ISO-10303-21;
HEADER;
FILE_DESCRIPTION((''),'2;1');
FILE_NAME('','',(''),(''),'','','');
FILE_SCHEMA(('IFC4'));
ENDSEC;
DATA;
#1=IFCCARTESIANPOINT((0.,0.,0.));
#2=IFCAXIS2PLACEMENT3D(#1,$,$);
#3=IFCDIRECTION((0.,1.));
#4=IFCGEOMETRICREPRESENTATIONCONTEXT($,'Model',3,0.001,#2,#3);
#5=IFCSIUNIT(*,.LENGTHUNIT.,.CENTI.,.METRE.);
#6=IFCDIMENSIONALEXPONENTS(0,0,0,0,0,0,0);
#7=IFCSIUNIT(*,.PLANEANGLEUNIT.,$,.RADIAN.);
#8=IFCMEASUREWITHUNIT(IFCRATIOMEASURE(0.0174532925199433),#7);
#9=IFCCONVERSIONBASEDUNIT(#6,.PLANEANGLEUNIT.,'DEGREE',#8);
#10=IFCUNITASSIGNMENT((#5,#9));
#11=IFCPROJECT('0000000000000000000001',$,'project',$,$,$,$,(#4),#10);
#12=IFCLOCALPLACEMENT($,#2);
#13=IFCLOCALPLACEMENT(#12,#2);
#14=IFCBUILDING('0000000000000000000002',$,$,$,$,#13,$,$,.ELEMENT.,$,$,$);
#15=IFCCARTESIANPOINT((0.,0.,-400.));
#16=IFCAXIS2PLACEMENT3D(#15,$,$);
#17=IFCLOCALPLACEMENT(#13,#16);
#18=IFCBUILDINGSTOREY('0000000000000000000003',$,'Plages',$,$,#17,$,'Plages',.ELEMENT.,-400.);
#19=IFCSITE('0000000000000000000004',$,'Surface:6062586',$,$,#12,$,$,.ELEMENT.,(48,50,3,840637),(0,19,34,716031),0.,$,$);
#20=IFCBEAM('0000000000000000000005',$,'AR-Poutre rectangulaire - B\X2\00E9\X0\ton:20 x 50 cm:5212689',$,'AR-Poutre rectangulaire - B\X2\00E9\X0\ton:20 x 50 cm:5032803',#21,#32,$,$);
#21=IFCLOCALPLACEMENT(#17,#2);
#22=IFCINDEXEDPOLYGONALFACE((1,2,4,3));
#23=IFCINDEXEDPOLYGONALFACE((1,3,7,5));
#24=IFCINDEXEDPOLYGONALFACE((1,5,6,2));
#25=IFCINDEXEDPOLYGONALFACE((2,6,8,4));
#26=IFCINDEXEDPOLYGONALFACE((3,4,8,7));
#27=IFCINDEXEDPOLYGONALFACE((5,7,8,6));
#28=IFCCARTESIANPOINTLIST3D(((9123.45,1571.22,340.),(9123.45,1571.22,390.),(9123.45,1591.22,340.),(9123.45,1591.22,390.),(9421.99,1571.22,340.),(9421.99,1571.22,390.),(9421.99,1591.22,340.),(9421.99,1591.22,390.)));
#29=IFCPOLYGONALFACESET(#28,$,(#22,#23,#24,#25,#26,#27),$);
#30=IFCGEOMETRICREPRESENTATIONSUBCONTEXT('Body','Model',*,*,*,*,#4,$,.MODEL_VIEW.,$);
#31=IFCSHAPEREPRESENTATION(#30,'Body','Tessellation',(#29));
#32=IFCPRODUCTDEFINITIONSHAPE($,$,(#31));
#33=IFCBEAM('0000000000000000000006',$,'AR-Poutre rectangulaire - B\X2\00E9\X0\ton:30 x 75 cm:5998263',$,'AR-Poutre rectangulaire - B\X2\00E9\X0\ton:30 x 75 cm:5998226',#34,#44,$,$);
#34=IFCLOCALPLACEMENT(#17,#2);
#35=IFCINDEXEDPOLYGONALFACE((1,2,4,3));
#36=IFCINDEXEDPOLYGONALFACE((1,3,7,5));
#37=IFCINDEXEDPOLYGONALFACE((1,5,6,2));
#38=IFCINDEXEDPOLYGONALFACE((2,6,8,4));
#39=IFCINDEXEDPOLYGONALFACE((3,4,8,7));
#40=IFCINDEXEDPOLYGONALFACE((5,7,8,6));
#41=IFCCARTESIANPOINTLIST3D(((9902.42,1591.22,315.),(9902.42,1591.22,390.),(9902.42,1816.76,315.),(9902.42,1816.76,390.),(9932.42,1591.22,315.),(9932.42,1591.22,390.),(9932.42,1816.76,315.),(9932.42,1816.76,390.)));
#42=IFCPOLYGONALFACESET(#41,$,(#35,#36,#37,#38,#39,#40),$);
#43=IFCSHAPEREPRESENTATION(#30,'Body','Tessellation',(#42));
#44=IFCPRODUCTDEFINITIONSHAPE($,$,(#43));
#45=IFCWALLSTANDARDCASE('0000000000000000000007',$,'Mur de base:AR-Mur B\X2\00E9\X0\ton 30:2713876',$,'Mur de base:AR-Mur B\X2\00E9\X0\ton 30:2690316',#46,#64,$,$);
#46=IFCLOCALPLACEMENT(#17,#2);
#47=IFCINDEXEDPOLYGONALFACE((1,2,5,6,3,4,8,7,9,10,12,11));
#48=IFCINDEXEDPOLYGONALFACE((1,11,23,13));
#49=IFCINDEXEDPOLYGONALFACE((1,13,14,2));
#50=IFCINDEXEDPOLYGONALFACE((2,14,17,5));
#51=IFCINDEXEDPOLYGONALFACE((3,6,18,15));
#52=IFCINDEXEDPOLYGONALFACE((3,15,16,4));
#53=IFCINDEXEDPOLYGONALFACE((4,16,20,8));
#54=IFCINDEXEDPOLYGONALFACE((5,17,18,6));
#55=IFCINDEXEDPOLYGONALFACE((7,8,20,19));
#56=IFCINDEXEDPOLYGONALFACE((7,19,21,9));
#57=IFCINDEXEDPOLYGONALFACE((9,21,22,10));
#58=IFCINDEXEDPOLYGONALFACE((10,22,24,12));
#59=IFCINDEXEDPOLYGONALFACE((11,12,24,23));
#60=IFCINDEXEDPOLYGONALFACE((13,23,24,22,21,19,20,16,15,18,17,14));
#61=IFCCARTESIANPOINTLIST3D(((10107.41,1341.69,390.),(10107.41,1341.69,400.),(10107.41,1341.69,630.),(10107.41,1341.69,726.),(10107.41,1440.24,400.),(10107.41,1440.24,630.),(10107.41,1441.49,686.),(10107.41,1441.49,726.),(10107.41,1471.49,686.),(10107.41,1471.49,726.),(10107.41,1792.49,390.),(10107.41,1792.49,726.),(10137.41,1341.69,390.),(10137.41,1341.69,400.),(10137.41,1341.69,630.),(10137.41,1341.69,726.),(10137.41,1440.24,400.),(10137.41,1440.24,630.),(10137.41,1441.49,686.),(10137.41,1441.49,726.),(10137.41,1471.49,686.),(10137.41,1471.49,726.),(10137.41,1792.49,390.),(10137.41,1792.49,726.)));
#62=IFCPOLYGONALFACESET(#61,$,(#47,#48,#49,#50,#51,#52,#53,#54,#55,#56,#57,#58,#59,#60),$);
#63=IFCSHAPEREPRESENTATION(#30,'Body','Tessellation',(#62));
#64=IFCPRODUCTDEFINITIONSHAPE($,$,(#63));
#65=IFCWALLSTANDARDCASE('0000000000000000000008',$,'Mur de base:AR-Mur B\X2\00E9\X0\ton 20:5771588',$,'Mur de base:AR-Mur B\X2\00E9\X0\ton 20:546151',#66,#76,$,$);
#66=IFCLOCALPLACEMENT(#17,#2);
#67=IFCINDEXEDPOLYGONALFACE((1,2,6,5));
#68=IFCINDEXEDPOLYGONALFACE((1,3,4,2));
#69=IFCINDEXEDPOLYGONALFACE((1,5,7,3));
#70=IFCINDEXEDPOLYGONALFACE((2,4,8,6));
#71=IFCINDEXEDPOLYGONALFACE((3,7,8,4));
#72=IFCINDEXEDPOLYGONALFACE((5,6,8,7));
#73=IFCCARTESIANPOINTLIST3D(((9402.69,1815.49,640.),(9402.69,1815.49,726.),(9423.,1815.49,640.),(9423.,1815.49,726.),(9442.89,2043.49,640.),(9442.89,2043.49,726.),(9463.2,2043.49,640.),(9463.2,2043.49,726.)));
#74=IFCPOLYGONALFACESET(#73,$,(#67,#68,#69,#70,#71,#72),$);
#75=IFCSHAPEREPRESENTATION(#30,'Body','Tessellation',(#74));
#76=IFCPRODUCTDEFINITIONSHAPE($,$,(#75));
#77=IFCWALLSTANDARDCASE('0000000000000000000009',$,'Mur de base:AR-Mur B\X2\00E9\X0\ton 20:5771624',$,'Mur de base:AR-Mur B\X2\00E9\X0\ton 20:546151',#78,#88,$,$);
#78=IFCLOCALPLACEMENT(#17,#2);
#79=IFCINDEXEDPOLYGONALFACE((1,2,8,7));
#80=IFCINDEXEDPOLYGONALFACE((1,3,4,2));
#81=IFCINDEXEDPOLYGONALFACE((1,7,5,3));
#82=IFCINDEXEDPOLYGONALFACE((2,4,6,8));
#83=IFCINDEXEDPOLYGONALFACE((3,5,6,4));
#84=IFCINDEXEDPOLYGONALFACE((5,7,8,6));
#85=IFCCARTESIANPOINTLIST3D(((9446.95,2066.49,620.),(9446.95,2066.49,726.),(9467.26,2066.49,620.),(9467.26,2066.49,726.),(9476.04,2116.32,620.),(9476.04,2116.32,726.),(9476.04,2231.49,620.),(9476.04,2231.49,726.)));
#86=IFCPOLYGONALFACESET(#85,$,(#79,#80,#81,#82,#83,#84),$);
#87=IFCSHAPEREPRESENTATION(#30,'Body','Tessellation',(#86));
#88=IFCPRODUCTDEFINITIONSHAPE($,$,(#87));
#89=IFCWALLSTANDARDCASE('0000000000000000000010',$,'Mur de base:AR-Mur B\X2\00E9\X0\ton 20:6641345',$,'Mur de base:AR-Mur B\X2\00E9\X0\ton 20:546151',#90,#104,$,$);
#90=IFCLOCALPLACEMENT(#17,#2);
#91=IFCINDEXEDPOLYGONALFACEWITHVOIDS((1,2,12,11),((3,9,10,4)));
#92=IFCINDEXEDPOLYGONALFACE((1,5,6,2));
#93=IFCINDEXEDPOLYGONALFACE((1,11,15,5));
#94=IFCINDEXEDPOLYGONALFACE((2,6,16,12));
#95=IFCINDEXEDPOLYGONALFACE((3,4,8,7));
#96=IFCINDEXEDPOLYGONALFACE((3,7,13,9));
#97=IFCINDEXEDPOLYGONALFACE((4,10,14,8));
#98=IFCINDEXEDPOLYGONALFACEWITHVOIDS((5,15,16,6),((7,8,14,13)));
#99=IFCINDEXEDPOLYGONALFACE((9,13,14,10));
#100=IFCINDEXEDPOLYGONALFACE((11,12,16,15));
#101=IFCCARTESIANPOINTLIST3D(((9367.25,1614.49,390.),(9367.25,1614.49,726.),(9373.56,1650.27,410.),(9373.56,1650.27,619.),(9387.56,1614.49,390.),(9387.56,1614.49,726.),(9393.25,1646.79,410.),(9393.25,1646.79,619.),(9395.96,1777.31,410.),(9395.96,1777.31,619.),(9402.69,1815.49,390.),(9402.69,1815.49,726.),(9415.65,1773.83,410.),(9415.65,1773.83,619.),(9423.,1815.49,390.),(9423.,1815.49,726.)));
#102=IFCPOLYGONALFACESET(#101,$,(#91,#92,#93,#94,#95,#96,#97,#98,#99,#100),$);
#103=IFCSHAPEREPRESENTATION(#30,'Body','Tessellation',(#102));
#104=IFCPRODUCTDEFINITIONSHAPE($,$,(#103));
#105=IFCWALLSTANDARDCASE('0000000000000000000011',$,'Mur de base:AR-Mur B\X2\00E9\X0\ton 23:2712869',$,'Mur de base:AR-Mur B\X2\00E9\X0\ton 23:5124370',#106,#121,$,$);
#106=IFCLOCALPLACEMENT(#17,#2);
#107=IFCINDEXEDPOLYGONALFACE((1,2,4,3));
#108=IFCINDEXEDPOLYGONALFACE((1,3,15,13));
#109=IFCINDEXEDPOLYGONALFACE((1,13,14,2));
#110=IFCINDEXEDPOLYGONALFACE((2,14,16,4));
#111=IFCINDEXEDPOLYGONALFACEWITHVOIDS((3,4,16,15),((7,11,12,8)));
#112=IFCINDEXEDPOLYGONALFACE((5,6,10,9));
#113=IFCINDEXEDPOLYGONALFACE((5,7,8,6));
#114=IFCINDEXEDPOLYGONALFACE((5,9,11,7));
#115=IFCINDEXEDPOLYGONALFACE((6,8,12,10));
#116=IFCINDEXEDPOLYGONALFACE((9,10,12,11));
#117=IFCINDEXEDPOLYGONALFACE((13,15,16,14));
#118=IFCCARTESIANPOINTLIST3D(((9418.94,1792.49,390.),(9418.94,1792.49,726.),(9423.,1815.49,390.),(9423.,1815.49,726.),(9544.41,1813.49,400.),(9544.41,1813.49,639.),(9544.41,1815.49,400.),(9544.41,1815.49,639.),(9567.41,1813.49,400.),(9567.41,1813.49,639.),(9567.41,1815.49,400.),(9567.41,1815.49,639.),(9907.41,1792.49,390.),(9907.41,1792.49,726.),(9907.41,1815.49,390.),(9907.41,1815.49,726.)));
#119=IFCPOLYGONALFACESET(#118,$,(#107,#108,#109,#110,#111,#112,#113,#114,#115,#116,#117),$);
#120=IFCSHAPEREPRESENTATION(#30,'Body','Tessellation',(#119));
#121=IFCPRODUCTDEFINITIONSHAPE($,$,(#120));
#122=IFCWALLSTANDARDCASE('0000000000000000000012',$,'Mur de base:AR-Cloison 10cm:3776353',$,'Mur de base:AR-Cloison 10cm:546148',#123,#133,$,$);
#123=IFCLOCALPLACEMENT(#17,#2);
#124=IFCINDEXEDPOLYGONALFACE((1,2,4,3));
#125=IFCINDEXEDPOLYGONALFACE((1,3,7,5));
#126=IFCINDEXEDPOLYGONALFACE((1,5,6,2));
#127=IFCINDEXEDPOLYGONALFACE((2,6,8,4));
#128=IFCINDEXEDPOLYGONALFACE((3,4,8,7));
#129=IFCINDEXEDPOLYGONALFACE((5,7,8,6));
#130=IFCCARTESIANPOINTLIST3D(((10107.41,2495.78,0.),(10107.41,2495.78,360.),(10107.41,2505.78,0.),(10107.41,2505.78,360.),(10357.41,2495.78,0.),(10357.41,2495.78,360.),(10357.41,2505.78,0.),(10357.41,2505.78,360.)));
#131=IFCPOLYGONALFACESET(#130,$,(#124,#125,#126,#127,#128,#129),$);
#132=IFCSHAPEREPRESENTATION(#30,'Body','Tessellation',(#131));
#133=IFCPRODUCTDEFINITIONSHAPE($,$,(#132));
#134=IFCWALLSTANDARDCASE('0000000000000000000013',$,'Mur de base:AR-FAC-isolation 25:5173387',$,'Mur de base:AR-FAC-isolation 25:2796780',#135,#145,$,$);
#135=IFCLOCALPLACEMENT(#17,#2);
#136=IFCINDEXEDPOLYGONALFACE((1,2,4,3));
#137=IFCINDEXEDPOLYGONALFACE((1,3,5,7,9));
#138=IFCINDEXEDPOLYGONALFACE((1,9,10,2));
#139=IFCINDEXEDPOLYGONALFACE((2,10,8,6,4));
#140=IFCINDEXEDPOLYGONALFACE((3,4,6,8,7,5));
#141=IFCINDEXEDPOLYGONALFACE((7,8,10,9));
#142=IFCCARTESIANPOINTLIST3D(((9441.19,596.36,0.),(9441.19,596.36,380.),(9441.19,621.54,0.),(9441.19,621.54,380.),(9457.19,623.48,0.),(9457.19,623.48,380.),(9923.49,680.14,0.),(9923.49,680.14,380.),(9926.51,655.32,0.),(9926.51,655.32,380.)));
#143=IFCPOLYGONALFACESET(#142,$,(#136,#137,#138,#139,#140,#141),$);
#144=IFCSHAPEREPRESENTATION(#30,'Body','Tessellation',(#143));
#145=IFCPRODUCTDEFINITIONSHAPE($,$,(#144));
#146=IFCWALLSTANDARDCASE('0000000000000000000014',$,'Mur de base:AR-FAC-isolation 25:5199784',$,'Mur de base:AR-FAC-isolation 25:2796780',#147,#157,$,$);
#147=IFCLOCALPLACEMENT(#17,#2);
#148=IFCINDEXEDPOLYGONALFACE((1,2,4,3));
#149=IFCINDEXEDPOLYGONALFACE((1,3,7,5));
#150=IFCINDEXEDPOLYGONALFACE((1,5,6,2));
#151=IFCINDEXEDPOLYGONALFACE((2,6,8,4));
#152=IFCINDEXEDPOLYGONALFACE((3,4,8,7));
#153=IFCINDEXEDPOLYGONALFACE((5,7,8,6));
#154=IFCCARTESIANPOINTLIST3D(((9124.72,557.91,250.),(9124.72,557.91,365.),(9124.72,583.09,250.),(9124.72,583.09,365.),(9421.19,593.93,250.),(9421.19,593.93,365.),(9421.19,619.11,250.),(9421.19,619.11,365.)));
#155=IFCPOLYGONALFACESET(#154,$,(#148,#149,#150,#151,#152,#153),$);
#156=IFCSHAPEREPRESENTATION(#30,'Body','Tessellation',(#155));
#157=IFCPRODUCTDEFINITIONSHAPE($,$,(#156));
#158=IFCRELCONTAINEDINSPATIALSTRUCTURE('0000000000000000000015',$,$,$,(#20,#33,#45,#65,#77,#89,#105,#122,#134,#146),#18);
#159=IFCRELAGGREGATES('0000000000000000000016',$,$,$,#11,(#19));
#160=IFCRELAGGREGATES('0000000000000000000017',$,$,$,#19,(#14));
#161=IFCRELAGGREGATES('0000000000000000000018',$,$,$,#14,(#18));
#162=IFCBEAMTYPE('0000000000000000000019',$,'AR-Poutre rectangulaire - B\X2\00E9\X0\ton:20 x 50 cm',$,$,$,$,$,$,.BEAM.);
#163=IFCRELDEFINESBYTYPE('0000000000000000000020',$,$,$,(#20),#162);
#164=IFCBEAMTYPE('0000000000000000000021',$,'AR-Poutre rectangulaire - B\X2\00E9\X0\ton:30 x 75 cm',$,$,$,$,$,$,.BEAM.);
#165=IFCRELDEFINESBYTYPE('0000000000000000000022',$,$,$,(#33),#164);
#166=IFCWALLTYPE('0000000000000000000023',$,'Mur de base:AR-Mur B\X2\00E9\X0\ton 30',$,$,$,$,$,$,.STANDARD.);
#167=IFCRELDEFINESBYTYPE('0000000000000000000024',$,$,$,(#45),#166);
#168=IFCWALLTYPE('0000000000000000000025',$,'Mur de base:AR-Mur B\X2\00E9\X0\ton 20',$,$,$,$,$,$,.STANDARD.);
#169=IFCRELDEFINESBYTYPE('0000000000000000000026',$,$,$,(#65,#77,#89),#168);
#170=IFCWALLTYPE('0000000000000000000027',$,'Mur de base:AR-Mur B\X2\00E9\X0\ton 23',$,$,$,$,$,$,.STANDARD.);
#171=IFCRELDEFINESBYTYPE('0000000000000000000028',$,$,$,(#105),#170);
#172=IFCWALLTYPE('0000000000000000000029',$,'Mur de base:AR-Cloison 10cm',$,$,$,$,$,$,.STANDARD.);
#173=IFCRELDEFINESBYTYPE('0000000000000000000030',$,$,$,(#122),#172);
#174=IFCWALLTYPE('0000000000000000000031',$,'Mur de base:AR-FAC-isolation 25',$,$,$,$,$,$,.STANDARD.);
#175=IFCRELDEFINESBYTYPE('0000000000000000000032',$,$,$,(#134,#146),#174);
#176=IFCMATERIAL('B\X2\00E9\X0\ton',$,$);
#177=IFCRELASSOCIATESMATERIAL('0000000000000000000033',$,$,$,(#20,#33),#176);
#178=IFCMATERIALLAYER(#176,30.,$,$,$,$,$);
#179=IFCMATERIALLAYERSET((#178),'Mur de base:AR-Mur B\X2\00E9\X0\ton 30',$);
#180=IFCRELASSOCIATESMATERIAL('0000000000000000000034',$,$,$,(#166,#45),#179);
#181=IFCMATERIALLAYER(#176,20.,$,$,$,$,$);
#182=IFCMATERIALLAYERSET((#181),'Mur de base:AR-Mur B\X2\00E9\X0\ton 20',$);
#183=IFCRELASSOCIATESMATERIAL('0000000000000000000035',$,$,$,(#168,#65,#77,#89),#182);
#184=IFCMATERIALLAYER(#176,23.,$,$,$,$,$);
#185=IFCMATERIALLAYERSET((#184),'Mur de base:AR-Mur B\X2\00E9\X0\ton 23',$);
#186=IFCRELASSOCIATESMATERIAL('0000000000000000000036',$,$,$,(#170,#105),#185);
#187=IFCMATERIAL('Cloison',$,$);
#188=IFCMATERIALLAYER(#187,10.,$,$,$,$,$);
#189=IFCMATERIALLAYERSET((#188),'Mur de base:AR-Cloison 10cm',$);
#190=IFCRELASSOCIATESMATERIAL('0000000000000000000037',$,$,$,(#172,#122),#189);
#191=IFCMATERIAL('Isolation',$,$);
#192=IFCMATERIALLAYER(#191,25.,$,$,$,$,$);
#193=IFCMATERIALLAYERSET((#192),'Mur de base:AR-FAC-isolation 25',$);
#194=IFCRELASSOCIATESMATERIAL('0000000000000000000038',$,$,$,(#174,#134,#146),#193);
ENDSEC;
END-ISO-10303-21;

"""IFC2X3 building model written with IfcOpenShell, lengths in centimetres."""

from ifc_helpers import new_model, entity, si_unit, converted_unit, direction, frame, frame_2d, origin, origin_2d_with_axis, place, context, subcontext, project, spatial, polyline, rectangle, outline, extrude, clip, bounded_halfspace, material, layer, layer_set, layer_usage, type_object, element, save


model = new_model("IFC2X3")

# Units and contexts
model_context = context("Model", 3, precision=0.001, world=origin(), true_north=direction((0.0, 1.0)))
body_context = subcontext(model_context, "Body", "Model", "MODEL_VIEW")
ifc_project = project(units=[si_unit("LENGTHUNIT", "METRE", prefix="CENTI"), converted_unit("PLANEANGLEUNIT", "DEGREE", entity("IfcRatioMeasure", 0.0174532925199433), si_unit("PLANEANGLEUNIT", "RADIAN"), dimensions=[0, 0, 0, 0, 0, 0, 0])], contexts=[model_context])

# Site, building, storey
site_placement = place(None, origin())
site = spatial("IfcSite", under=ifc_project, at=site_placement, Name="Surface:6062586", CompositionType="ELEMENT", RefLatitude=(48, 50, 3, 840637), RefLongitude=(0, 19, 34, 716031), RefElevation=0.0)
building_placement = place(site_placement, origin())
building = spatial("IfcBuilding", under=site, at=building_placement, CompositionType="ELEMENT")
storey_placement = place(building_placement, frame((0.0, 0.0, -400.0)))
storey = spatial("IfcBuildingStorey", under=building, at=storey_placement, Name="Plages", LongName="Plages", CompositionType="ELEMENT", Elevation=-400.0)

# Beams
ifc_material_1 = material(Name="Béton")
beam_type_1 = type_object("IfcBeamType", Name="AR-Poutre rectangulaire - Béton:20 x 50 cm", PredefinedType="BEAM")
beam_1_placement = place(storey_placement, frame((9420.72, 1591.22, 390.0), z_axis=(0.0, 0.0, 1.0), x_axis=(-1.0, 0.0, 0.0)))
element("IfcBeam", 1, at=beam_1_placement, inside=storey, type_object=beam_type_1, material=ifc_material_1, Name="AR-Poutre rectangulaire - Béton:20 x 50 cm:5212689", ObjectType="AR-Poutre rectangulaire - Béton:20 x 50 cm:5032803", context=body_context, shape_type="SweptSolid", body=[
    extrude(rectangle(XDim=50.0, YDim=20.0, at=frame_2d((0.0, 0.0), x_axis=(1.0, 0.0))), frame((-1.27, 10.0, -25.0), z_axis=(1.0, 0.0, 0.0), x_axis=(0.0, 0.0, -1.0)), (0.0, 0.0, 1.0), 298.54),
])
beam_type_2 = type_object("IfcBeamType", Name="AR-Poutre rectangulaire - Béton:30 x 75 cm", PredefinedType="BEAM")
beam_2_placement = place(storey_placement, frame((9932.42, 1815.49, 390.0), z_axis=(0.0, 0.0, 1.0), x_axis=(0.0, -1.0, 0.0)))
element("IfcBeam", 2, at=beam_2_placement, inside=storey, type_object=beam_type_2, material=ifc_material_1, Name="AR-Poutre rectangulaire - Béton:30 x 75 cm:5998263", ObjectType="AR-Poutre rectangulaire - Béton:30 x 75 cm:5998226", context=body_context, shape_type="SweptSolid", body=[
    extrude(rectangle(XDim=75.0, YDim=30.0, at=origin_2d_with_axis()), frame((-1.27, -15.0, -37.5), z_axis=(1.0, 0.0, 0.0), x_axis=(0.0, 0.0, -1.0)), (0.0, 0.0, 1.0), 225.54),
])

# Wall, opening
ifc_layer_1 = layer(ifc_material_1, 30.0)
ifc_layer_set_1 = layer_set([ifc_layer_1], Name="Mur de base:AR-Mur Béton 30")
ifc_layer_usage_1 = layer_usage(ifc_layer_set_1, "AXIS2", "NEGATIVE", 15.0)
wall_type_1 = type_object("IfcWallType", Name="Mur de base:AR-Mur Béton 30", PredefinedType="STANDARD", material=ifc_layer_set_1)
wall_1_placement = place(storey_placement, frame((10122.41, 1792.49, 390.0), z_axis=(0.0, 0.0, 1.0), x_axis=(0.0, -1.0, 0.0)))
wall_1 = element("IfcWallStandardCase", 3, at=wall_1_placement, inside=storey, type_object=wall_type_1, material=ifc_layer_usage_1, Name="Mur de base:AR-Mur Béton 30:2713876", ObjectType="Mur de base:AR-Mur Béton 30:2690316", context=body_context, shape_type="Clipping", body=[
    clip(extrude(rectangle(XDim=450.8, YDim=30.0, at=frame_2d((225.4, 0.0), x_axis=(-1.0, 0.0))), origin(), (0.0, 0.0, 1.0), 336.0), bounded_halfspace(frame((351.0, -15.0, 296.0), z_axis=(0.0, 0.0, -1.0), x_axis=(0.0, -1.0, 0.0)), True, frame((351.0, -15.0, 296.0), z_axis=(0.0, 0.0, -1.0), x_axis=(0.0, -1.0, 0.0)), polyline([(0.0, 0.0), (0.0, 30.0), (-30.0, 30.0), (-30.0, 0.0), (0.0, 0.0)]))),
])
opening_1_placement = place(wall_1_placement, frame((502.25, -30.24, 10.0)))
element("IfcOpeningElement", 4, at=opening_1_placement, cuts=wall_1, ObjectType="Opening", context=body_context, shape_type="SweptSolid", body=[
    extrude(rectangle(XDim=230.0, YDim=150.0, at=frame_2d((0.0, 0.0), x_axis=(0.0, 1.0))), frame((-75.0, 0.0, 115.0), z_axis=(0.0, 1.0, 0.0), x_axis=(-1.0, 0.0, 0.0)), (0.0, 0.0, 1.0), 60.48),
])

# Walls
ifc_layer_2 = layer(ifc_material_1, 20.0)
ifc_layer_set_2 = layer_set([ifc_layer_2], Name="Mur de base:AR-Mur Béton 20")
ifc_layer_usage_2 = layer_usage(ifc_layer_set_2, "AXIS2", "NEGATIVE", 10.0)
wall_type_2 = type_object("IfcWallType", Name="Mur de base:AR-Mur Béton 20", PredefinedType="STANDARD", material=ifc_layer_set_2)
wall_2_placement = place(storey_placement, frame((9453.35, 2045.23, 640.0), z_axis=(0.0, 0.0, 1.0), x_axis=(-0.173648, -0.984808, 0.0)))
element("IfcWallStandardCase", 5, at=wall_2_placement, inside=storey, type_object=wall_type_2, material=ifc_layer_usage_2, Name="Mur de base:AR-Mur Béton 20:5771588", ObjectType="Mur de base:AR-Mur Béton 20:546151", context=body_context, shape_type="SweptSolid", body=[
    extrude(outline(polyline([(235.04, -10.0), (231.52, 10.0), (0.0, 10.0), (3.53, -10.0), (235.04, -10.0)])), origin(), (0.0, 0.0, 1.0), 86.0),
])
ifc_layer_usage_3 = layer_usage(ifc_layer_set_2, "AXIS2", "NEGATIVE", 10.0)
wall_3_placement = place(storey_placement, frame((9485.89, 2229.76, 620.0), z_axis=(0.0, 0.0, 1.0), x_axis=(-0.173648, -0.984808, 0.0)))
element("IfcWallStandardCase", 6, at=wall_3_placement, inside=storey, type_object=wall_type_2, material=ifc_layer_usage_3, Name="Mur de base:AR-Mur Béton 20:5771624", ObjectType="Mur de base:AR-Mur Béton 20:546151", context=body_context, shape_type="SweptSolid", body=[
    extrude(outline(polyline([(167.55, -10.0), (164.02, 10.0), (113.43, 10.0), (0.0, -10.0), (167.55, -10.0)])), origin(), (0.0, 0.0, 1.0), 106.0),
])

# Walls, openings
ifc_layer_usage_4 = layer_usage(ifc_layer_set_2, "AXIS2", "NEGATIVE", 10.0)
wall_4_placement = place(storey_placement, frame((9413.15, 1817.23, 390.0), z_axis=(0.0, 0.0, 1.0), x_axis=(-0.173648, -0.984808, 0.0)))
wall_4 = element("IfcWallStandardCase", 7, at=wall_4_placement, inside=storey, type_object=wall_type_2, material=ifc_layer_usage_4, Name="Mur de base:AR-Mur Béton 20:6641345", ObjectType="Mur de base:AR-Mur Béton 20:546151", context=body_context, shape_type="SweptSolid", body=[
    extrude(outline(polyline([(207.63, -10.0), (204.1, 10.0), (23.35, 10.0), (0.0, 10.0), (3.53, -10.0), (207.63, -10.0)])), origin(), (0.0, 0.0, 1.0), 336.0),
])
opening_2_placement = place(wall_4_placement, frame((171.3, 10.0, 20.0)))
element("IfcOpeningElement", 8, at=opening_2_placement, cuts=wall_4, ObjectType="Opening", context=body_context, shape_type="SweptSolid", body=[
    extrude(rectangle(XDim=209.0, YDim=129.0, at=frame_2d((104.5, 64.5), x_axis=(1.0, 0.0))), frame((0.0, 0.0, 0.0), z_axis=(0.0, -1.0, 0.0), x_axis=(0.0, 0.0, 1.0)), (0.0, 0.0, 1.0), 20.0),
])
ifc_layer_3 = layer(ifc_material_1, 23.0)
ifc_layer_set_3 = layer_set([ifc_layer_3], Name="Mur de base:AR-Mur Béton 23")
ifc_layer_usage_5 = layer_usage(ifc_layer_set_3, "AXIS2", "NEGATIVE", 11.5)
wall_type_3 = type_object("IfcWallType", Name="Mur de base:AR-Mur Béton 23", PredefinedType="STANDARD", material=ifc_layer_set_3)
wall_5_placement = place(storey_placement, frame((9418.94, 1803.99, 390.0)))
wall_5 = element("IfcWallStandardCase", 9, at=wall_5_placement, inside=storey, type_object=wall_type_3, material=ifc_layer_usage_5, Name="Mur de base:AR-Mur Béton 23:2712869", ObjectType="Mur de base:AR-Mur Béton 23:5124370", context=body_context, shape_type="SweptSolid", body=[
    extrude(outline(polyline([(488.46, -11.5), (488.46, 11.5), (148.46, 11.5), (125.46, 11.5), (4.06, 11.5), (0.0, -11.5), (488.46, -11.5)])), origin(), (0.0, 0.0, 1.0), 336.0),
])
opening_3_placement = place(wall_5_placement, frame((125.46, 9.5, 10.0)))
element("IfcOpeningElement", 10, at=opening_3_placement, cuts=wall_5, ObjectType="Opening", context=body_context, shape_type="SweptSolid", body=[
    extrude(rectangle(XDim=239.0, YDim=23.0, at=frame_2d((0.0, 0.0), x_axis=(0.0, 1.0))), frame((11.5, 0.0, 119.5), z_axis=(0.0, 1.0, 0.0), x_axis=(-1.0, 0.0, 0.0)), (0.0, 0.0, 1.0), 228.0),
])

# Wall
ifc_material_2 = material(Name="Cloison")
ifc_layer_4 = layer(ifc_material_2, 10.0)
ifc_layer_set_4 = layer_set([ifc_layer_4], Name="Mur de base:AR-Cloison 10cm")
ifc_layer_usage_6 = layer_usage(ifc_layer_set_4, "AXIS2", "NEGATIVE", 5.0)
wall_type_4 = type_object("IfcWallType", Name="Mur de base:AR-Cloison 10cm", PredefinedType="STANDARD", material=ifc_layer_set_4)
wall_6_placement = place(storey_placement, frame((10107.41, 2500.78, 0.0)))
element("IfcWallStandardCase", 11, at=wall_6_placement, inside=storey, type_object=wall_type_4, material=ifc_layer_usage_6, Name="Mur de base:AR-Cloison 10cm:3776353", ObjectType="Mur de base:AR-Cloison 10cm:546148", context=body_context, shape_type="SweptSolid", body=[
    extrude(rectangle(XDim=250.0, YDim=10.0, at=frame_2d((125.0, 0.0), x_axis=(-1.0, 0.0))), origin(), (0.0, 0.0, 1.0), 360.0),
])

# Shared definitions
ifc_material_3 = material(Name="Isolation")

# Walls
ifc_layer_5 = layer(ifc_material_3, 25.0)
ifc_layer_set_5 = layer_set([ifc_layer_5], Name="Mur de base:AR-FAC-isolation 25")
ifc_layer_usage_7 = layer_usage(ifc_layer_set_5, "AXIS2", "NEGATIVE", 12.5)
wall_type_5 = type_object("IfcWallType", Name="Mur de base:AR-FAC-isolation 25", PredefinedType="STANDARD", material=ifc_layer_set_5)
wall_7_placement = place(storey_placement, frame((9925.0, 667.73, 0.0), z_axis=(0.0, 0.0, 1.0), x_axis=(-0.9927, -0.120613, 0.0)))
element("IfcWallStandardCase", 12, at=wall_7_placement, inside=storey, type_object=wall_type_5, material=ifc_layer_usage_7, Name="Mur de base:AR-FAC-isolation 25:5173387", ObjectType="Mur de base:AR-FAC-isolation 25:2796780", context=body_context, shape_type="SweptSolid", body=[
    extrude(outline(polyline([(485.85, -12.5), (488.89, 12.5), (0.0, 12.5), (0.0, -12.5), (469.73, -12.5), (485.85, -12.5)])), origin(), (0.0, 0.0, 1.0), 380.0),
])
ifc_layer_usage_8 = layer_usage(ifc_layer_set_5, "AXIS2", "NEGATIVE", 12.5)
wall_8_placement = place(storey_placement, frame((9422.7, 606.7, 250.0), z_axis=(0.0, 0.0, 1.0), x_axis=(-0.9927, -0.120613, 0.0)))
element("IfcWallStandardCase", 13, at=wall_8_placement, inside=storey, type_object=wall_type_5, material=ifc_layer_usage_8, Name="Mur de base:AR-FAC-isolation 25:5199784", ObjectType="Mur de base:AR-FAC-isolation 25:2796780", context=body_context, shape_type="SweptSolid", body=[
    extrude(outline(polyline([(298.65, -12.5), (301.69, 12.5), (3.04, 12.5), (0.0, -12.5), (298.65, -12.5)])), origin(), (0.0, 0.0, 1.0), 115.0),
])

save(model, "model.ifc")
